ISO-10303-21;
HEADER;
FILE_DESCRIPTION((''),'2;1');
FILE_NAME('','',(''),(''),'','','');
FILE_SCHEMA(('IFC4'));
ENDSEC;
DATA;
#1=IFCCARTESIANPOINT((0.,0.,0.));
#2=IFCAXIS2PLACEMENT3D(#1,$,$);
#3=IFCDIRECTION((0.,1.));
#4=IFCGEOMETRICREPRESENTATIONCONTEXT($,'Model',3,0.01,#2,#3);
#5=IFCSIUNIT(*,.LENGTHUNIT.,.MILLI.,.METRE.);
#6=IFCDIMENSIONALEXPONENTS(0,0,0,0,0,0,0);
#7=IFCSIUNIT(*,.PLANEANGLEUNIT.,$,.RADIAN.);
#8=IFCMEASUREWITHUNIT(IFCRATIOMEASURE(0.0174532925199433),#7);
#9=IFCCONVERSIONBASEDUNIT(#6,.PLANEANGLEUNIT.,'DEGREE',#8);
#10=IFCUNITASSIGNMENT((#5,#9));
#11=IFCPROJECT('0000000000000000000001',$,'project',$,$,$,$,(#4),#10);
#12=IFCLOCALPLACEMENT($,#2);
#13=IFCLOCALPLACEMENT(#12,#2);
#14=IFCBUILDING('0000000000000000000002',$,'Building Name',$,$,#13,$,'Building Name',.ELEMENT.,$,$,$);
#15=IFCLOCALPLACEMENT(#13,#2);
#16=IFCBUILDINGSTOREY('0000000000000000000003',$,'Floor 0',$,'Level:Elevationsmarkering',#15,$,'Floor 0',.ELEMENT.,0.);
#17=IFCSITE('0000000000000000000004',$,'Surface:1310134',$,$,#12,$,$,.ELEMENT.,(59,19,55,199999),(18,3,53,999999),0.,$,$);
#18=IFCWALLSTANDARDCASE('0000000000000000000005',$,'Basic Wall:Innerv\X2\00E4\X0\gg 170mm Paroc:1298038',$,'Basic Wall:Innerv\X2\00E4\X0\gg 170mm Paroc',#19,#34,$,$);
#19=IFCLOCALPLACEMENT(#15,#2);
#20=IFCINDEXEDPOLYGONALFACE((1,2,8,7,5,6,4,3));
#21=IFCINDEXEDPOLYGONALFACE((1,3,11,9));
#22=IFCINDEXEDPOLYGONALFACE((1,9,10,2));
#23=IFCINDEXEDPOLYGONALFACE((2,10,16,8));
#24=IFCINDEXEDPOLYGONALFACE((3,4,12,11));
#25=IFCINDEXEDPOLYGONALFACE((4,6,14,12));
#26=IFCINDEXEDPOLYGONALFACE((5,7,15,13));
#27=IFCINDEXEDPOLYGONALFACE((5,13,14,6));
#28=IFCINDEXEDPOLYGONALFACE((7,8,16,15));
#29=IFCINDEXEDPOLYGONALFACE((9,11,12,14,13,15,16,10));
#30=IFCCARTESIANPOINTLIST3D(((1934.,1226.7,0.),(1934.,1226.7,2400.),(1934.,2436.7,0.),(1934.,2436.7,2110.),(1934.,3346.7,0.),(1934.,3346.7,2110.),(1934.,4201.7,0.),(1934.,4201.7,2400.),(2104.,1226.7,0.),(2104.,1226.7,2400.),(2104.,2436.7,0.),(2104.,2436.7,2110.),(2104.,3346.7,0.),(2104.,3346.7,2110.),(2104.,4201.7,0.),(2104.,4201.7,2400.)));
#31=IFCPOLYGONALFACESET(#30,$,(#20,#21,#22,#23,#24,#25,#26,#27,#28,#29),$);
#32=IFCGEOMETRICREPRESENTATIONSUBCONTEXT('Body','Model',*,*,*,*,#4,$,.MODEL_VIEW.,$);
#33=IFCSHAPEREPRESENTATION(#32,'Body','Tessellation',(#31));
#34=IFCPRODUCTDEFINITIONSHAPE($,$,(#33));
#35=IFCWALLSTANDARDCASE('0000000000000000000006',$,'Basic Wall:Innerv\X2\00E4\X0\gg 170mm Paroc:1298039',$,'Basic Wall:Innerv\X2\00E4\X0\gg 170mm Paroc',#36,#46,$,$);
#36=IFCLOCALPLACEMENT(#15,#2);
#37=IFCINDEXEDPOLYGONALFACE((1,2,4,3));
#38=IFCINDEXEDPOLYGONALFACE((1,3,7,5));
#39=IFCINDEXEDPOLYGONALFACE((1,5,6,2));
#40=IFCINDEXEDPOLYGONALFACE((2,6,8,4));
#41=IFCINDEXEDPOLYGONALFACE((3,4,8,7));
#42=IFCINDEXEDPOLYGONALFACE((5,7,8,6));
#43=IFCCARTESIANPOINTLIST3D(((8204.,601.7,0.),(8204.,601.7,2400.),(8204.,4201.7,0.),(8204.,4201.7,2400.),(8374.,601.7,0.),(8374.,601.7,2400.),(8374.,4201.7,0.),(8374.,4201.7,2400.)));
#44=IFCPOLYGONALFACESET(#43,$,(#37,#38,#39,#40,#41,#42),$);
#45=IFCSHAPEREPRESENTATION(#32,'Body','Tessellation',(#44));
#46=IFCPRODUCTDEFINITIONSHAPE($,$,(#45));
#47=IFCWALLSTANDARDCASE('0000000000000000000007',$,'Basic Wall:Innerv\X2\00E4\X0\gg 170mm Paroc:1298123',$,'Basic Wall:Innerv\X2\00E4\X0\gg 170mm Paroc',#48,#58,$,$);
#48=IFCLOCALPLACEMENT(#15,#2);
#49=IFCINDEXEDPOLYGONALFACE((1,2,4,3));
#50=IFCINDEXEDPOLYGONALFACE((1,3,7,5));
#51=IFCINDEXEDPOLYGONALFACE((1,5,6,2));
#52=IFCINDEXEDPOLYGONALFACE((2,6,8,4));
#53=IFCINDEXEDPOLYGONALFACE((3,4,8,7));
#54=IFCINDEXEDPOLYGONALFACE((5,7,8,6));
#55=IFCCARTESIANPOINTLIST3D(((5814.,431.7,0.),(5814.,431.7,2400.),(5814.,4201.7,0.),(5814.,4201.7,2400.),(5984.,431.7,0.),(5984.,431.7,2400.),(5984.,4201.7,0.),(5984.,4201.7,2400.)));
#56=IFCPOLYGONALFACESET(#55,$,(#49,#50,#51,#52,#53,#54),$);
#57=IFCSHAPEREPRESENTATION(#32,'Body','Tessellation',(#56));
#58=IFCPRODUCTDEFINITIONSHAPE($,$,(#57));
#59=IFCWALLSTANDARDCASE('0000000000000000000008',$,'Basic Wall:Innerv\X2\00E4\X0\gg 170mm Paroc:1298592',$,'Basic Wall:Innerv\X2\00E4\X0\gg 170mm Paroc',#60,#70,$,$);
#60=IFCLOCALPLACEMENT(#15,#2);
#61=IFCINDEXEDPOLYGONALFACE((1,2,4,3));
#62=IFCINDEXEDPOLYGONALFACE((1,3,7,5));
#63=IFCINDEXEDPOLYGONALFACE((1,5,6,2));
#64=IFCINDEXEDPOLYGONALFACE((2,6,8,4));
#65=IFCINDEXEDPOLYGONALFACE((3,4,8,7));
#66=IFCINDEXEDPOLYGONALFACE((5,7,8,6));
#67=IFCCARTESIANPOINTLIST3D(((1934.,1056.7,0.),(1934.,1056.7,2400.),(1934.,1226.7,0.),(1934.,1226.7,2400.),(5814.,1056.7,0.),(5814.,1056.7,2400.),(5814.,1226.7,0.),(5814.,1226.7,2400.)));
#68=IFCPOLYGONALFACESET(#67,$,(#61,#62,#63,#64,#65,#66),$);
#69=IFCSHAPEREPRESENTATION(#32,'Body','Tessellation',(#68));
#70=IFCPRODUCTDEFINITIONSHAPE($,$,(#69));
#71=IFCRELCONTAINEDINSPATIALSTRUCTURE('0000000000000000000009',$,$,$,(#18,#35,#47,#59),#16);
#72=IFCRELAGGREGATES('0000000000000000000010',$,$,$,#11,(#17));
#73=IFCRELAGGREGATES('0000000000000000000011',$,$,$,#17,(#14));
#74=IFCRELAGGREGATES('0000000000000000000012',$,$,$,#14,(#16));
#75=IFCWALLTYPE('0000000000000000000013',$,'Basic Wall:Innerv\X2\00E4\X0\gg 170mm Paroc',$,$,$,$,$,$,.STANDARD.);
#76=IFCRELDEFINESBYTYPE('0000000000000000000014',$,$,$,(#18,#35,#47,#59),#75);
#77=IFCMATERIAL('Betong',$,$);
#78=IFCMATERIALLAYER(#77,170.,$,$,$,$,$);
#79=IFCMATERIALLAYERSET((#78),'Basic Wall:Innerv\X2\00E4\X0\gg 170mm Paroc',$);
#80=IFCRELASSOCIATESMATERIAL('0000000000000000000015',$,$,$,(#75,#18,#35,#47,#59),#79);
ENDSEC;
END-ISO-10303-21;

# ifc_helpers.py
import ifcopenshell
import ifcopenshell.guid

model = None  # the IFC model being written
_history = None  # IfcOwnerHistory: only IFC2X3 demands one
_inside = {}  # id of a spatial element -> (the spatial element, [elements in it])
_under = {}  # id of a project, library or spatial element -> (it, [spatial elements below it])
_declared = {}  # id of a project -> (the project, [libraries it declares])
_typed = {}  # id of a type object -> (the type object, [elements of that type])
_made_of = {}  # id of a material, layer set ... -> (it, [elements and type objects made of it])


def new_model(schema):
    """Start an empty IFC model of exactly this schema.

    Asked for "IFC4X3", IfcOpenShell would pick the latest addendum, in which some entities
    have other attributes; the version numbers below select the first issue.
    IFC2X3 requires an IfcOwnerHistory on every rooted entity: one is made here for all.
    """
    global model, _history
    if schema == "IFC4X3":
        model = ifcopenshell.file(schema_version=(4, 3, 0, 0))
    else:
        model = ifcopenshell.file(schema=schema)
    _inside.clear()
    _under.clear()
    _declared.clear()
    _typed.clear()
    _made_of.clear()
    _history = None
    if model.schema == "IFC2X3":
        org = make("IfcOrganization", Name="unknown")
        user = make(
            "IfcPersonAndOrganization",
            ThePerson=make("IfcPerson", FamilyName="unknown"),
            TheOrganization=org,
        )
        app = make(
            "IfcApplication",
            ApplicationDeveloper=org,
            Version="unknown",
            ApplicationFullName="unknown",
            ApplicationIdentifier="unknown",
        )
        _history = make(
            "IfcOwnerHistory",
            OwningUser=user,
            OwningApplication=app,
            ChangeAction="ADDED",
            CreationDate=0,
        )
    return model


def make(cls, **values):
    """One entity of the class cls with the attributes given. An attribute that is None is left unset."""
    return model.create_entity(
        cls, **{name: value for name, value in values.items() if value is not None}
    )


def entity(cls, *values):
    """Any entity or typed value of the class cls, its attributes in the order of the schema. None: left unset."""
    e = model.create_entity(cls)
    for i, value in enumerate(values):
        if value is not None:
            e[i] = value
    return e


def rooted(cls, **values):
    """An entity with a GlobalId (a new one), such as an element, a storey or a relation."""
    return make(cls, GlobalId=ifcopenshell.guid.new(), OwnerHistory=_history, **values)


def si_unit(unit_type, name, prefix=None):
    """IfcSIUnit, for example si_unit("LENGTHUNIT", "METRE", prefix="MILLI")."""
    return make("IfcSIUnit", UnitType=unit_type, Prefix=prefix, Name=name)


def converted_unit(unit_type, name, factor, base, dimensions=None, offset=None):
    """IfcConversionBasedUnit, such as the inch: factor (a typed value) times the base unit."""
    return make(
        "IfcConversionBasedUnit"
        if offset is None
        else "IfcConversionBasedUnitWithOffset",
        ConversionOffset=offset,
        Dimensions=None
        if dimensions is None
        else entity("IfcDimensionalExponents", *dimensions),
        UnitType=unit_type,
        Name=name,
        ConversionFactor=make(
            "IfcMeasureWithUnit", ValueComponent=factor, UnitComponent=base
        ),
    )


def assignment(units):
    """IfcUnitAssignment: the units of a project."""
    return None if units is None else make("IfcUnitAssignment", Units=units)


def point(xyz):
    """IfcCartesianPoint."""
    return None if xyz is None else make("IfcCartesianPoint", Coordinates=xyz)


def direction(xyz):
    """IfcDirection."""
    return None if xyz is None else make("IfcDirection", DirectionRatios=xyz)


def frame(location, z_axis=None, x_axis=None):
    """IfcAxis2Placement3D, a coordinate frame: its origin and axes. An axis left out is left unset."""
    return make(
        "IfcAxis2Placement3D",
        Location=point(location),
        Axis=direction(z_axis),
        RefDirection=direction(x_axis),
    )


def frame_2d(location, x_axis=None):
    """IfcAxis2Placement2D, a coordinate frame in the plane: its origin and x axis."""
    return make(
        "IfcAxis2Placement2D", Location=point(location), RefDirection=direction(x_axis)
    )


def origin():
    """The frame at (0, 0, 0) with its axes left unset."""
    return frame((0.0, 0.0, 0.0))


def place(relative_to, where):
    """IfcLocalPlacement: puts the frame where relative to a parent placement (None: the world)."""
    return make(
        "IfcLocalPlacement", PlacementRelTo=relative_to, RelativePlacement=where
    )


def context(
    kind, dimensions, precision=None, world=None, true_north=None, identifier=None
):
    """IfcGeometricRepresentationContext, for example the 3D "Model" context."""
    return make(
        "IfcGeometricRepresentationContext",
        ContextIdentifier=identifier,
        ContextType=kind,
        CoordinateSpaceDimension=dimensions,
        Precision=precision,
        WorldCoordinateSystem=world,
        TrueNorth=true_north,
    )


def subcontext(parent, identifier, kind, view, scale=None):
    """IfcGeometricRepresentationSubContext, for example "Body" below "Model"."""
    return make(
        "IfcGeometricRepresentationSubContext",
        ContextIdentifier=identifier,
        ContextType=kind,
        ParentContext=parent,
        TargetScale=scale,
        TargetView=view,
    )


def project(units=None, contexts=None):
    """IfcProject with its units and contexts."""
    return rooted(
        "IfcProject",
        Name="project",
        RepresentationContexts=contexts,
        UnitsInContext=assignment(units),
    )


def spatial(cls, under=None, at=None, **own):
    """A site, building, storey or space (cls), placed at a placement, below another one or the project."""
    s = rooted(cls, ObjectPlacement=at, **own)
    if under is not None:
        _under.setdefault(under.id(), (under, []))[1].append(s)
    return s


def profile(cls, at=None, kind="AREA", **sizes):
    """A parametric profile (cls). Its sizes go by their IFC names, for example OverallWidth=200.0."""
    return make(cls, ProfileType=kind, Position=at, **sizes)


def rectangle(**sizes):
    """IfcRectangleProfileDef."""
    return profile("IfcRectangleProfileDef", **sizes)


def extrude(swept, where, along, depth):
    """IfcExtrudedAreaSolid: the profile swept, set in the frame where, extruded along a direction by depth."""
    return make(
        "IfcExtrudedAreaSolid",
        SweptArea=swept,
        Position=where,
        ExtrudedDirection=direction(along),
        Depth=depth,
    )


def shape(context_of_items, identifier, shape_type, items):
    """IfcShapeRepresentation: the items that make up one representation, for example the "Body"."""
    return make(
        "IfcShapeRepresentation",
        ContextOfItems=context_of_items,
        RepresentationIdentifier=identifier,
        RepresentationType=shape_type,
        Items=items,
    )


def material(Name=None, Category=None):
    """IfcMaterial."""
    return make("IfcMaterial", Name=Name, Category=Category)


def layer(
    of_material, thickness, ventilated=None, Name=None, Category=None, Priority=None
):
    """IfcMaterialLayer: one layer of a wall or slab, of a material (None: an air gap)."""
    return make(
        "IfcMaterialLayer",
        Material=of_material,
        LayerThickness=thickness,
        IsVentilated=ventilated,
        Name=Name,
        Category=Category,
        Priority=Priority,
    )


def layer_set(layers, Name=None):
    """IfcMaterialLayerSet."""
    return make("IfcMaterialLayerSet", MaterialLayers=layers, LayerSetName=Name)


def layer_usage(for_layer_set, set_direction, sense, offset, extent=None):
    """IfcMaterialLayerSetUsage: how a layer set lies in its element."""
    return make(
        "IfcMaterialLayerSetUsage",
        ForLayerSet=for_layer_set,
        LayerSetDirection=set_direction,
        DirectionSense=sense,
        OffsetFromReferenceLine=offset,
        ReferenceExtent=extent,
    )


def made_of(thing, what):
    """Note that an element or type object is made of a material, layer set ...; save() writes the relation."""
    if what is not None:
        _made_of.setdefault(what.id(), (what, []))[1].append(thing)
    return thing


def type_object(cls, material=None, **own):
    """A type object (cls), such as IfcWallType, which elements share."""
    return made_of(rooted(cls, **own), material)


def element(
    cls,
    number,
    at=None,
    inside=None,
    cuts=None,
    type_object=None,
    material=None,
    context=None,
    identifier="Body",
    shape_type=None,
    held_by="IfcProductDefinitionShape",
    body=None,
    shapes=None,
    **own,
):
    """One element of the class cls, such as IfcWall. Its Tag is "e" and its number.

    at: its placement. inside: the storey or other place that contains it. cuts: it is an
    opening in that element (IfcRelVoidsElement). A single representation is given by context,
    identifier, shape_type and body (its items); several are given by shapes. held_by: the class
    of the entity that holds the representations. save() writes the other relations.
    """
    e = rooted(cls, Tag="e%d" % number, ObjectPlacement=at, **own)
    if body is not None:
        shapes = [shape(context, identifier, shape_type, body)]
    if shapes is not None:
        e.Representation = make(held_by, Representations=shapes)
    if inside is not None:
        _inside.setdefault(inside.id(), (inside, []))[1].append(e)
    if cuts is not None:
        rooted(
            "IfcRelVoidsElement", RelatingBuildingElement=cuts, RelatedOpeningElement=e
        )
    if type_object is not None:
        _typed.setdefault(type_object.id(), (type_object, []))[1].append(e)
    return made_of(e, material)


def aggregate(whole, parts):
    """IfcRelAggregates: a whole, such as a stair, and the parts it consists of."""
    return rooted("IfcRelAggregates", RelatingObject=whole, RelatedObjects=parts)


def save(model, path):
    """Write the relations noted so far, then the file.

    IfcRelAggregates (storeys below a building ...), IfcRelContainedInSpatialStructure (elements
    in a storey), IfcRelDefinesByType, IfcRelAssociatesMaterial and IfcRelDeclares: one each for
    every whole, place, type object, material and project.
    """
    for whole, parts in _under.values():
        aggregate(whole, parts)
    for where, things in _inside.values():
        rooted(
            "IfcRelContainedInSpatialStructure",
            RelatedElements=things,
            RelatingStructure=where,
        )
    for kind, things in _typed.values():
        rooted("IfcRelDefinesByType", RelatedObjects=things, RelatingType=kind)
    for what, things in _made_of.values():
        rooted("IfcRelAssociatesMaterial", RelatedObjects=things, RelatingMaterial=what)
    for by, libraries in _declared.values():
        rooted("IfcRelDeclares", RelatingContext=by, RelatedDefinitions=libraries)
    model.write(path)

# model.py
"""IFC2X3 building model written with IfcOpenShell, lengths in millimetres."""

from ifc_helpers import new_model, entity, si_unit, converted_unit, direction, frame, frame_2d, origin, place, context, subcontext, project, spatial, rectangle, extrude, material, layer, layer_set, layer_usage, type_object, element, save


model = new_model("IFC2X3")

# Units and contexts
model_context = context("Model", 3, precision=0.01, world=origin(), true_north=direction((0.0, 1.0)))
body_context = subcontext(model_context, "Body", "Model", "MODEL_VIEW")
ifc_project = project(units=[si_unit("LENGTHUNIT", "METRE", prefix="MILLI"), converted_unit("PLANEANGLEUNIT", "DEGREE", entity("IfcRatioMeasure", 0.0174532925199433), si_unit("PLANEANGLEUNIT", "RADIAN"), dimensions=[0, 0, 0, 0, 0, 0, 0])], contexts=[model_context])

# Site, building, storey
site_placement = place(None, origin())
site = spatial("IfcSite", under=ifc_project, at=site_placement, Name="Surface:1310134", CompositionType="ELEMENT", RefLatitude=(59, 19, 55, 199999), RefLongitude=(18, 3, 53, 999999), RefElevation=0.0)
building_placement = place(site_placement, origin())
building = spatial("IfcBuilding", under=site, at=building_placement, Name="Building Name", LongName="Building Name", CompositionType="ELEMENT")
storey_placement = place(building_placement, origin())
storey = spatial("IfcBuildingStorey", under=building, at=storey_placement, Name="Floor 0", ObjectType="Level:Elevationsmarkering", LongName="Floor 0", CompositionType="ELEMENT", Elevation=0.0)

# Shared definitions
ifc_material_1 = material(Name="Betong")

# Shared definitions
ifc_layer_1 = layer(ifc_material_1, 170.0)
ifc_layer_set_1 = layer_set([ifc_layer_1], Name="Basic Wall:Innervägg 170mm Paroc")
wall_type_1 = type_object("IfcWallType", Name="Basic Wall:Innervägg 170mm Paroc", PredefinedType="STANDARD", material=ifc_layer_set_1)

# Wall, opening
ifc_layer_usage_1 = layer_usage(ifc_layer_set_1, "AXIS2", "NEGATIVE", 85.0)
wall_1_placement = place(storey_placement, frame((2019.0, 4201.7, 0.0), z_axis=(0.0, 0.0, 1.0), x_axis=(0.0, -1.0, 0.0)))
wall_1 = element("IfcWallStandardCase", 1, at=wall_1_placement, inside=storey, type_object=wall_type_1, material=ifc_layer_usage_1, Name="Basic Wall:Innervägg 170mm Paroc:1298038", ObjectType="Basic Wall:Innervägg 170mm Paroc", context=body_context, shape_type="SweptSolid", body=[
    extrude(rectangle(XDim=2975.0, YDim=170.0, at=frame_2d((1487.5, 0.0), x_axis=(-1.0, 0.0))), origin(), (0.0, 0.0, 1.0), 2400.0),
])
opening_1_placement = place(wall_1_placement, frame((1765.0, 85.0, 0.0)))
element("IfcOpeningElement", 2, at=opening_1_placement, cuts=wall_1, ObjectType="Opening", context=body_context, shape_type="SweptSolid", body=[
    extrude(rectangle(XDim=2110.0, YDim=910.0, at=frame_2d((1055.0, 455.0), x_axis=(1.0, 0.0))), frame((0.0, 0.0, 0.0), z_axis=(0.0, -1.0, 0.0), x_axis=(0.0, 0.0, 1.0)), (0.0, 0.0, 1.0), 170.0),
])

# Walls
ifc_layer_usage_2 = layer_usage(ifc_layer_set_1, "AXIS2", "NEGATIVE", 85.0)
wall_2_placement = place(storey_placement, frame((8289.0, 4201.7, 0.0), z_axis=(0.0, 0.0, 1.0), x_axis=(0.0, -1.0, 0.0)))
element("IfcWallStandardCase", 3, at=wall_2_placement, inside=storey, type_object=wall_type_1, material=ifc_layer_usage_2, Name="Basic Wall:Innervägg 170mm Paroc:1298039", ObjectType="Basic Wall:Innervägg 170mm Paroc", context=body_context, shape_type="SweptSolid", body=[
    extrude(rectangle(XDim=3600.0, YDim=170.0, at=frame_2d((1800.0, 0.0), x_axis=(-1.0, 0.0))), origin(), (0.0, 0.0, 1.0), 2400.0),
])
ifc_layer_usage_3 = layer_usage(ifc_layer_set_1, "AXIS2", "NEGATIVE", 85.0)
wall_3_placement = place(storey_placement, frame((5899.0, 4201.7, 0.0), z_axis=(0.0, 0.0, 1.0), x_axis=(0.0, -1.0, 0.0)))
element("IfcWallStandardCase", 4, at=wall_3_placement, inside=storey, type_object=wall_type_1, material=ifc_layer_usage_3, Name="Basic Wall:Innervägg 170mm Paroc:1298123", ObjectType="Basic Wall:Innervägg 170mm Paroc", context=body_context, shape_type="SweptSolid", body=[
    extrude(rectangle(XDim=3770.0, YDim=170.0, at=frame_2d((1885.0, 0.0), x_axis=(-1.0, 0.0))), origin(), (0.0, 0.0, 1.0), 2400.0),
])
ifc_layer_usage_4 = layer_usage(ifc_layer_set_1, "AXIS2", "NEGATIVE", 85.0)
wall_4_placement = place(storey_placement, frame((5814.0, 1141.7, 0.0), z_axis=(0.0, 0.0, 1.0), x_axis=(-1.0, 0.0, 0.0)))
element("IfcWallStandardCase", 5, at=wall_4_placement, inside=storey, type_object=wall_type_1, material=ifc_layer_usage_4, Name="Basic Wall:Innervägg 170mm Paroc:1298592", ObjectType="Basic Wall:Innervägg 170mm Paroc", context=body_context, shape_type="SweptSolid", body=[
    extrude(rectangle(XDim=3880.0, YDim=170.0, at=frame_2d((1940.0, 0.0), x_axis=(-1.0, 0.0))), origin(), (0.0, 0.0, 1.0), 2400.0),
])

save(model, "model.ifc")
